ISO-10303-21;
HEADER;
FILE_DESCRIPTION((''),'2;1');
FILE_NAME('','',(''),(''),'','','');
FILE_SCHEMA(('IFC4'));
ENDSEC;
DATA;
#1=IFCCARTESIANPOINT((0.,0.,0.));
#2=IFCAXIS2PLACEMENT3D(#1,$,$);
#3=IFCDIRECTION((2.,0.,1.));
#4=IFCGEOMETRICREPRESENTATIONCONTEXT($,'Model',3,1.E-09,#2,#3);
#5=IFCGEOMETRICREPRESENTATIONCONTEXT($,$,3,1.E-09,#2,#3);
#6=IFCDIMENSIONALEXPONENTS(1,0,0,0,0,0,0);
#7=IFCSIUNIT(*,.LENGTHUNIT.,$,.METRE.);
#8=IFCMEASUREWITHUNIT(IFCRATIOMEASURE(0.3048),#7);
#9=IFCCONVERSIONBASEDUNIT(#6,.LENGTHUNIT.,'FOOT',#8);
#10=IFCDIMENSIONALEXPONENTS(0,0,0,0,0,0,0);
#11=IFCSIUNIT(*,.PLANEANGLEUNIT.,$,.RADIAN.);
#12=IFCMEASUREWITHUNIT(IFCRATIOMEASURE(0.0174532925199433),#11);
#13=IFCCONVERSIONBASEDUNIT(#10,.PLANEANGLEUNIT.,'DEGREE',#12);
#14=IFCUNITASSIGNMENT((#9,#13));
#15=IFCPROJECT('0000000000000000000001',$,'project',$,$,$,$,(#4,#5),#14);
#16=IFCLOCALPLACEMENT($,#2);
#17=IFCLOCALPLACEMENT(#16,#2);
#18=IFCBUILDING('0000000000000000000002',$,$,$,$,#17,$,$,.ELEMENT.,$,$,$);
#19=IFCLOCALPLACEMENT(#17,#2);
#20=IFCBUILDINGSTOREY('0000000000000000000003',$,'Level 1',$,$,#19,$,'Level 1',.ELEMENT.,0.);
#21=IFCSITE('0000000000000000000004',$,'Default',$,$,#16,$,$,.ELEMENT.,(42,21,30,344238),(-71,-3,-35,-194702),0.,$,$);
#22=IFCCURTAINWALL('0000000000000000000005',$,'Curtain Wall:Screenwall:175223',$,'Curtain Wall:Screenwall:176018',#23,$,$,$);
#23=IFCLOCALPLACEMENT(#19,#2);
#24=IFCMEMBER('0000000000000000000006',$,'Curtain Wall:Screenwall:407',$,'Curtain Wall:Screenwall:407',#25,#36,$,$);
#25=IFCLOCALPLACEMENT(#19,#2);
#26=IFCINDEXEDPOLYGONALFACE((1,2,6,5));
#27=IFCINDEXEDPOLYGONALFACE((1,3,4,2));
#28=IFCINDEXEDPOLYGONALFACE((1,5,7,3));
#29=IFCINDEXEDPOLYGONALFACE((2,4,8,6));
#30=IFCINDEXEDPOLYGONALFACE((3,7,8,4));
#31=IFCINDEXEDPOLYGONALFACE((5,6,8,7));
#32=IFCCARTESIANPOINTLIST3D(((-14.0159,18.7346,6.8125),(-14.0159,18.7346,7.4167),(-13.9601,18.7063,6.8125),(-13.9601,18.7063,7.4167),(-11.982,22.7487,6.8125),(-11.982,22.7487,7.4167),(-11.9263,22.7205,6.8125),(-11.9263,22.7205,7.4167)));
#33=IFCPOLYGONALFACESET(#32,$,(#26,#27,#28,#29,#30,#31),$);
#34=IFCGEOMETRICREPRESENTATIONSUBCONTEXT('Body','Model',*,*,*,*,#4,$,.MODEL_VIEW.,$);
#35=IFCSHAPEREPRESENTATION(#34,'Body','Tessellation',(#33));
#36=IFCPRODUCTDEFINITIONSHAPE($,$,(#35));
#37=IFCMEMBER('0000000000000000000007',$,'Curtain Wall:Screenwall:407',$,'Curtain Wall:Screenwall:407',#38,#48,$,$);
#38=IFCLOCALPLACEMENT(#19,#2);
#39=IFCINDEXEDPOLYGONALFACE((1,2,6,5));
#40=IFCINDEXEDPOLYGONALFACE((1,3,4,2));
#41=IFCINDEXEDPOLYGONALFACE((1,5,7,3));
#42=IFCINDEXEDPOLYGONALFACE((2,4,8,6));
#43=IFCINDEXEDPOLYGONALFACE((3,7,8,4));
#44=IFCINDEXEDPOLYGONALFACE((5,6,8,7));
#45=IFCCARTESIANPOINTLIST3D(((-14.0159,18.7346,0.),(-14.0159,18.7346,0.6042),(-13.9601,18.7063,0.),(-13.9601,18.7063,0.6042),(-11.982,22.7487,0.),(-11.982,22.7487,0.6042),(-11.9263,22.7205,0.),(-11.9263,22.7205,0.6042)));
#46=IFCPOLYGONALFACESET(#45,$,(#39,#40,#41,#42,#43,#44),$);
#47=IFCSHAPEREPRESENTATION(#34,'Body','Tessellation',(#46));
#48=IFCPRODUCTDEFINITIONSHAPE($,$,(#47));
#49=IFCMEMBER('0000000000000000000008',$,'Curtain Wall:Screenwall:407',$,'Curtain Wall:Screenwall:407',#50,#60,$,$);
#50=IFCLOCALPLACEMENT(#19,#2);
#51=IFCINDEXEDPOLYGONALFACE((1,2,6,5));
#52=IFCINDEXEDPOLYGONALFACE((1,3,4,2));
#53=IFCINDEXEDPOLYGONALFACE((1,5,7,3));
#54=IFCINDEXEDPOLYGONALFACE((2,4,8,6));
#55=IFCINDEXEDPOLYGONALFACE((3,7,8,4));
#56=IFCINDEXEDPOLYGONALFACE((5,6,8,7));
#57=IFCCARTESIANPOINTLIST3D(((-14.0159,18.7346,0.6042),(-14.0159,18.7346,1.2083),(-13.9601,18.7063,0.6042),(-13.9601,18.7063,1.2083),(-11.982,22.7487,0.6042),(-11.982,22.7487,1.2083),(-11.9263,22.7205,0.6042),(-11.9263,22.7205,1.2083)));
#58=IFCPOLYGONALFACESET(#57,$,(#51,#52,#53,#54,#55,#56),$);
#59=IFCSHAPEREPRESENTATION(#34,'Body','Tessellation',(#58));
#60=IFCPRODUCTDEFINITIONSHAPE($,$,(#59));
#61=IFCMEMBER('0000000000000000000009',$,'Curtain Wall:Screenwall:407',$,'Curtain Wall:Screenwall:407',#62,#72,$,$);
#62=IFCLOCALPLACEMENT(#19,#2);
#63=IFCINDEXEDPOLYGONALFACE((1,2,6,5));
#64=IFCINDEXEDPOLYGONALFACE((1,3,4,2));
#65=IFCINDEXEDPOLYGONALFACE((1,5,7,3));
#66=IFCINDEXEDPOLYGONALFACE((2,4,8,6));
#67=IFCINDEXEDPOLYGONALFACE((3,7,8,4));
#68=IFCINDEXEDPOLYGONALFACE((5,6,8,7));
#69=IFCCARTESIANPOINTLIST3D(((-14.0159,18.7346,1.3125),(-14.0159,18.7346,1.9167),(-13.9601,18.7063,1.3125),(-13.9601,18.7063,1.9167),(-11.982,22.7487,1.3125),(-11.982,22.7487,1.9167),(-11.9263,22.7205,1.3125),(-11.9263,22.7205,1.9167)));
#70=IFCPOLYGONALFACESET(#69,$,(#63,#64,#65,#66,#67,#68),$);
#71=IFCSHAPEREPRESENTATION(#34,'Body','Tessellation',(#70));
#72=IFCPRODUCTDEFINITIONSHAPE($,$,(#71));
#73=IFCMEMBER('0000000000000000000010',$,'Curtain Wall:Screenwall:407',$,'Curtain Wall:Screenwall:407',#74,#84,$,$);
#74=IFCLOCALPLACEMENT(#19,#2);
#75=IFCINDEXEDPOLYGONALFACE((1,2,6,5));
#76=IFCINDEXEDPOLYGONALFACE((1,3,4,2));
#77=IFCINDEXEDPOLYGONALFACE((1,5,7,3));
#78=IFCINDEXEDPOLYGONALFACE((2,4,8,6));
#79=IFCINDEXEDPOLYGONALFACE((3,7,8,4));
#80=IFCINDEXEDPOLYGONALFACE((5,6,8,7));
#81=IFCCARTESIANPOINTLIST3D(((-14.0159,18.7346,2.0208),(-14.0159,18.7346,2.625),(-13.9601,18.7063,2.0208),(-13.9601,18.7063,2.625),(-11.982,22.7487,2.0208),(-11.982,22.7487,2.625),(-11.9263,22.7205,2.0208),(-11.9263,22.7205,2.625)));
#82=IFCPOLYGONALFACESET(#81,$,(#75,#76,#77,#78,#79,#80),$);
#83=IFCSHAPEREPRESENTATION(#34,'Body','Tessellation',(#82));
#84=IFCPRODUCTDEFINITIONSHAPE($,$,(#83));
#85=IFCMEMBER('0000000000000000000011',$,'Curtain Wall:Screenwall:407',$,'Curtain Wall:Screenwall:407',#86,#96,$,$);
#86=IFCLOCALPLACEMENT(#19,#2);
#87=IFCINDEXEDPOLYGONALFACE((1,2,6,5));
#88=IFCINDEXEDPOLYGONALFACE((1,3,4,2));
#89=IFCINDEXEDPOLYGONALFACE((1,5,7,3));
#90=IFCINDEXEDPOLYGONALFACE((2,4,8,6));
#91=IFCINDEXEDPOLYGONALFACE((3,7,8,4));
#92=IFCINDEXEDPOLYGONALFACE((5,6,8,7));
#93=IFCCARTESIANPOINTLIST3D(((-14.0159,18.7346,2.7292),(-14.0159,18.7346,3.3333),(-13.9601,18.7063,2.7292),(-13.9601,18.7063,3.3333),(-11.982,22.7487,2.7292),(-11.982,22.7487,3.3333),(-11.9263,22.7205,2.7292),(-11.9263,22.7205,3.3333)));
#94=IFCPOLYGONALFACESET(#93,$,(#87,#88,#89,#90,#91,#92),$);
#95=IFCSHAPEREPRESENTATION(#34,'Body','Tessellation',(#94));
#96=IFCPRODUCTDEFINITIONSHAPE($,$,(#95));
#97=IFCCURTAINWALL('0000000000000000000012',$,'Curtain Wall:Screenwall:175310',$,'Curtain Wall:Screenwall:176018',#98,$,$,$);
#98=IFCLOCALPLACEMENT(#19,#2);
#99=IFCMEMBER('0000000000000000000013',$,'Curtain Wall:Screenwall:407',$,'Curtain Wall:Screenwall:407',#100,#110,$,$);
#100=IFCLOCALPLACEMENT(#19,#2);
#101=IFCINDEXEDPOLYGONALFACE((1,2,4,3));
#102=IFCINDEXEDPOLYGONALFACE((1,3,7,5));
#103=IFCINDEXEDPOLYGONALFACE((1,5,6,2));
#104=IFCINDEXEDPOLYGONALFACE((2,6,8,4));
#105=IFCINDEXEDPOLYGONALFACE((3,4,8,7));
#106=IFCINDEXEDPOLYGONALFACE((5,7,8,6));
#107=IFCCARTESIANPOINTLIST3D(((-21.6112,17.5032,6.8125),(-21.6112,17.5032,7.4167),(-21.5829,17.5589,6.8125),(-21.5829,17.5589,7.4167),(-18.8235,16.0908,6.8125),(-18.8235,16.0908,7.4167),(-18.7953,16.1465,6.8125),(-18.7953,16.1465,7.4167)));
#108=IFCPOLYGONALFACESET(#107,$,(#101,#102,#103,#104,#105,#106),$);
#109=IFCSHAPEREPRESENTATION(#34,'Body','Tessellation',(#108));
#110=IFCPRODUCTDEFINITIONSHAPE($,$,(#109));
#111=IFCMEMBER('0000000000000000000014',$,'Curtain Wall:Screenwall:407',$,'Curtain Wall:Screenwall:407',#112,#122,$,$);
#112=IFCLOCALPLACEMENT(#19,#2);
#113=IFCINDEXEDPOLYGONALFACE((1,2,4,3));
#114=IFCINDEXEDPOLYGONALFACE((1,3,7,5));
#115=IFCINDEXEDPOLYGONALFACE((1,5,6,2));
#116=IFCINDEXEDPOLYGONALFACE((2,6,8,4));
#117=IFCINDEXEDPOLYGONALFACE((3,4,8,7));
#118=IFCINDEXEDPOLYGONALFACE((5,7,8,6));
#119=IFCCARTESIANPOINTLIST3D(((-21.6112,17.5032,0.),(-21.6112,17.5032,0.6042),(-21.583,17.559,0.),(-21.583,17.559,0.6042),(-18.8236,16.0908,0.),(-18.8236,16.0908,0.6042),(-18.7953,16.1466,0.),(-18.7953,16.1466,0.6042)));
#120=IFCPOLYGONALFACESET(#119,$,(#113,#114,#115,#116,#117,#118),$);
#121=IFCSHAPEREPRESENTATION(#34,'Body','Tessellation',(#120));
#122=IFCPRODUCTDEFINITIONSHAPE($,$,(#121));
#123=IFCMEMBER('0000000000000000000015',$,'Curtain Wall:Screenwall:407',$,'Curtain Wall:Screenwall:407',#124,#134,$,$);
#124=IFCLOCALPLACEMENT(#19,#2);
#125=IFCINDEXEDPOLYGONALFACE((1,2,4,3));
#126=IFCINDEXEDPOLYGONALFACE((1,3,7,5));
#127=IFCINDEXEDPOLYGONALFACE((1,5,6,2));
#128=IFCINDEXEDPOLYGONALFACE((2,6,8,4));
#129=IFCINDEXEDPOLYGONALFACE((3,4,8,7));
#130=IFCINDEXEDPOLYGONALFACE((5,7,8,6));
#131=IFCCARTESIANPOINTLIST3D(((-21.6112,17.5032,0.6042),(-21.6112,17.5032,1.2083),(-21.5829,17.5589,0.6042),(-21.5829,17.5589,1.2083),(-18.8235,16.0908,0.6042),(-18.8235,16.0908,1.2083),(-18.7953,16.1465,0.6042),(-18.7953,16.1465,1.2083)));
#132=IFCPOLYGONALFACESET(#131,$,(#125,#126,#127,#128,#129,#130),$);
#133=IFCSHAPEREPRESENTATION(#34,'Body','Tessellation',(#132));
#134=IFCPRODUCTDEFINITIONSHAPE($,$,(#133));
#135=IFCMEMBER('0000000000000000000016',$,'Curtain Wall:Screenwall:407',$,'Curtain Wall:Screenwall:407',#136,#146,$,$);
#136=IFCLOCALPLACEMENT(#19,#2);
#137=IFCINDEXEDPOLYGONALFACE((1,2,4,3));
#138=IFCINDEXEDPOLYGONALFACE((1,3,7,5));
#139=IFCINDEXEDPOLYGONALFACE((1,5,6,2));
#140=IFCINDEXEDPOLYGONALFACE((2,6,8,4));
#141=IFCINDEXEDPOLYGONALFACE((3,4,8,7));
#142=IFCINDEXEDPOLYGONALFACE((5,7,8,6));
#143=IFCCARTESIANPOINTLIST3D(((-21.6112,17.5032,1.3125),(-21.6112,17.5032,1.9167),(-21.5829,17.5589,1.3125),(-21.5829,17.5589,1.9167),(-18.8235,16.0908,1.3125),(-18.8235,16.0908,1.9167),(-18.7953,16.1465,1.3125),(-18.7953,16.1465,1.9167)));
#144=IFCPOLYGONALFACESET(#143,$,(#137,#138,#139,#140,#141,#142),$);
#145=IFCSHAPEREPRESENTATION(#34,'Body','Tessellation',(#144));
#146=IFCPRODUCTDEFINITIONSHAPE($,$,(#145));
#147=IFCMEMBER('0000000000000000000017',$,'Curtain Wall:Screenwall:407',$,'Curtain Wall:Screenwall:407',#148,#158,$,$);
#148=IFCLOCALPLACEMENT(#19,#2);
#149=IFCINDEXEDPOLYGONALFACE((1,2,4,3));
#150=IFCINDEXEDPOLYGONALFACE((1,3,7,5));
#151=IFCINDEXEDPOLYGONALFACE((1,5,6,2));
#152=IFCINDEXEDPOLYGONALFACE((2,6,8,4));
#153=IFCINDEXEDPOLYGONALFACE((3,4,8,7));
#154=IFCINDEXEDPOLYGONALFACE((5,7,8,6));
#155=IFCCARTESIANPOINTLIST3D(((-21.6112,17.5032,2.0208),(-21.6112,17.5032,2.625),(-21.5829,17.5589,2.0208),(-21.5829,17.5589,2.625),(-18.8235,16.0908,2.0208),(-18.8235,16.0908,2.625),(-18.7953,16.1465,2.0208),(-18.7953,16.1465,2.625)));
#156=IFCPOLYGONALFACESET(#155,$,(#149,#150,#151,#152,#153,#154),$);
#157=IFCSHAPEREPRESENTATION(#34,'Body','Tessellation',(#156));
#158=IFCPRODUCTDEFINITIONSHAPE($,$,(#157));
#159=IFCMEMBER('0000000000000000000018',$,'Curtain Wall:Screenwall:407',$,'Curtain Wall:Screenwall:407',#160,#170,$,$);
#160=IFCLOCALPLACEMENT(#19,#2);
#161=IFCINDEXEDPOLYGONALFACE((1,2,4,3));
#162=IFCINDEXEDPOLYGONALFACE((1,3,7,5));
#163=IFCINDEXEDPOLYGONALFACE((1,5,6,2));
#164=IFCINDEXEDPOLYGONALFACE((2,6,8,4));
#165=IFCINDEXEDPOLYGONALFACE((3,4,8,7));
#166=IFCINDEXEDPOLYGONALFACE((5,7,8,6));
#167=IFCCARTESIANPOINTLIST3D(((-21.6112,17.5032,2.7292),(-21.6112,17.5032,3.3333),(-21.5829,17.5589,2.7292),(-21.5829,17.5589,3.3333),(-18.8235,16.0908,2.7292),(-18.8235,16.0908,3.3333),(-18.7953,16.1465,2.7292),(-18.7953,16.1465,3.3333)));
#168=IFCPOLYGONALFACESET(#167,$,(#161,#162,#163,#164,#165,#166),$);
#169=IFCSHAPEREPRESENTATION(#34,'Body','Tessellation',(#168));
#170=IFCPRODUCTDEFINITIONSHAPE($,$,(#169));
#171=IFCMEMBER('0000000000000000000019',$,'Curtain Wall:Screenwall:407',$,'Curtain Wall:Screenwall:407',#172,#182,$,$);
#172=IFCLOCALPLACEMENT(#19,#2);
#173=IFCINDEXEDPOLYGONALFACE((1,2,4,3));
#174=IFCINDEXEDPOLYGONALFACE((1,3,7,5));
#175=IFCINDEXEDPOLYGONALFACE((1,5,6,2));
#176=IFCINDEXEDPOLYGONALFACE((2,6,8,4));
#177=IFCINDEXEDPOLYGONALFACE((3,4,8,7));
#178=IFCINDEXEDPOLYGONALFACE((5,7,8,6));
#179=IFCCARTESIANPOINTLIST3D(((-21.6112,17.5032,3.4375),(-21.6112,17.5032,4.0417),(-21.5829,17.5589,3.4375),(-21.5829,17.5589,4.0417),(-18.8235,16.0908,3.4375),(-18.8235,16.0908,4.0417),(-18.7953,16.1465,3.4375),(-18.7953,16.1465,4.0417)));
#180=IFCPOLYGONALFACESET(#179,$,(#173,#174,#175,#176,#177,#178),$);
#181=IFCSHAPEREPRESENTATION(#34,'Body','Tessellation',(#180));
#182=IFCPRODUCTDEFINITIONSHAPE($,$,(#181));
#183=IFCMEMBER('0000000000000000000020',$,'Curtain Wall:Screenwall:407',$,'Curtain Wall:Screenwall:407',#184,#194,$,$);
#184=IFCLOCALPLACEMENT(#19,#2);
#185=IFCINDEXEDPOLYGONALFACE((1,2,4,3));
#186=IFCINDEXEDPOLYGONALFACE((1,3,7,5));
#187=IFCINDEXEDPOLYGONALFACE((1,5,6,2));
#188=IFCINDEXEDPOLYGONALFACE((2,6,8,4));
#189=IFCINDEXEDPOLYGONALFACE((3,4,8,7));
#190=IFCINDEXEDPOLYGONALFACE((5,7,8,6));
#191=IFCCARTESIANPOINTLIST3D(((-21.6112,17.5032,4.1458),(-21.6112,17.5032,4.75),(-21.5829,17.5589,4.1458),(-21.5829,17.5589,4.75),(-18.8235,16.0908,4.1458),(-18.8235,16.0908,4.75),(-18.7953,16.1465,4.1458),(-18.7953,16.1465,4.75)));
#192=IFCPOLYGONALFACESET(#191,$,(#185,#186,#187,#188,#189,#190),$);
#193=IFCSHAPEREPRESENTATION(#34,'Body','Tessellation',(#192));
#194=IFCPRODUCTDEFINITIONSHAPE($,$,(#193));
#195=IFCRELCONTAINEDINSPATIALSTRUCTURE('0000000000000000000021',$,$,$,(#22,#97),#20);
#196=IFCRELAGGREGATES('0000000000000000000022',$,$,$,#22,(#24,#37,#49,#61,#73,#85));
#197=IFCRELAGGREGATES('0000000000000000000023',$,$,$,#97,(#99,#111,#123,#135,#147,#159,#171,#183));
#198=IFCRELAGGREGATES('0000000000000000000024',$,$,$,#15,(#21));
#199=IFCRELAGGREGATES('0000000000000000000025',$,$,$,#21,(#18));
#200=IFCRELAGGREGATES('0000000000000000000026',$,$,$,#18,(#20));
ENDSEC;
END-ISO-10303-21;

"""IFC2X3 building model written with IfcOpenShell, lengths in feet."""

from ifc_helpers import new_model, entity, si_unit, converted_unit, direction, frame, frame_2d, origin, origin_2d_with_axis, place, context, subcontext, project, spatial, rectangle, extrude, element, aggregate, save


model = new_model("IFC2X3")

# Units and contexts
model_context = context("Model", 3, precision=1e-09, world=origin(), true_north=direction((2.0, 0.0, 1.0)))
context_of_model = context(None, 3, precision=1e-09, world=origin(), true_north=direction((2.0, 0.0, 1.0)))
body_context = subcontext(model_context, "Body", "Model", "MODEL_VIEW")
ifc_project = project(units=[converted_unit("LENGTHUNIT", "FOOT", entity("IfcRatioMeasure", 0.3048), si_unit("LENGTHUNIT", "METRE"), dimensions=[1, 0, 0, 0, 0, 0, 0]), converted_unit("PLANEANGLEUNIT", "DEGREE", entity("IfcRatioMeasure", 0.0174532925199433), si_unit("PLANEANGLEUNIT", "RADIAN"), dimensions=[0, 0, 0, 0, 0, 0, 0])], contexts=[model_context, context_of_model])

# Site, building, storey
site_placement = place(None, origin())
site = spatial("IfcSite", under=ifc_project, at=site_placement, Name="Default", CompositionType="ELEMENT", RefLatitude=(42, 21, 30, 344238), RefLongitude=(-71, -3, -35, -194702), RefElevation=0.0)
building_placement = place(site_placement, origin())
building = spatial("IfcBuilding", under=site, at=building_placement, CompositionType="ELEMENT")
storey_placement = place(building_placement, origin())
storey = spatial("IfcBuildingStorey", under=building, at=storey_placement, Name="Level 1", LongName="Level 1", CompositionType="ELEMENT", Elevation=0.0)

# Curtain walls, members
curtain_wall_1_placement = place(storey_placement, origin())
curtain_wall_1 = element("IfcCurtainWall", 1, at=curtain_wall_1_placement, inside=storey, Name="Curtain Wall:Screenwall:175223", ObjectType="Curtain Wall:Screenwall:176018")
member_1_placement = place(curtain_wall_1_placement, frame((-14.0159, 18.7063, 6.8125)))
member_1 = element("IfcMember", 2, at=member_1_placement, Name="Curtain Wall:Screenwall:407", ObjectType="Curtain Wall:Screenwall:407", context=body_context, shape_type="SweptSolid", body=[
    extrude(rectangle(XDim=4.5, YDim=0.0625, at=origin_2d_with_axis()), frame((1.0448, 2.0212, 0.0), z_axis=(0.0, 0.0, 1.0), x_axis=(-0.451968, -0.892034, 0.0)), (0.0, 0.0, 1.0), 0.6042),
])
member_2_placement = place(curtain_wall_1_placement, frame((-14.0159, 18.7063, 0.0)))
member_2 = element("IfcMember", 3, at=member_2_placement, Name="Curtain Wall:Screenwall:407", ObjectType="Curtain Wall:Screenwall:407", context=body_context, shape_type="SweptSolid", body=[
    extrude(rectangle(XDim=4.5, YDim=0.0625, at=frame_2d((0.0, 0.0), x_axis=(1.0, 0.0))), frame((1.0448, 2.0212, 0.0), z_axis=(0.0, 0.0, 1.0), x_axis=(0.451968, 0.892034, 0.0)), (0.0, 0.0, 1.0), 0.6042),
])
member_3_placement = place(curtain_wall_1_placement, frame((-14.0159, 18.7063, 0.6042)))
member_3 = element("IfcMember", 4, at=member_3_placement, Name="Curtain Wall:Screenwall:407", ObjectType="Curtain Wall:Screenwall:407", context=body_context, shape_type="SweptSolid", body=[
    extrude(rectangle(XDim=4.5, YDim=0.0625, at=frame_2d((0.0, 0.0), x_axis=(1.0, 0.0))), frame((1.0448, 2.0212, 0.0), z_axis=(0.0, 0.0, 1.0), x_axis=(-0.451968, -0.892034, 0.0)), (0.0, 0.0, 1.0), 0.6042),
])
member_4_placement = place(curtain_wall_1_placement, frame((-14.0159, 18.7063, 1.3125)))
member_4 = element("IfcMember", 5, at=member_4_placement, Name="Curtain Wall:Screenwall:407", ObjectType="Curtain Wall:Screenwall:407", context=body_context, shape_type="SweptSolid", body=[
    extrude(rectangle(XDim=4.5, YDim=0.0625, at=frame_2d((0.0, 0.0), x_axis=(1.0, 0.0))), frame((1.0448, 2.0212, 0.0), z_axis=(0.0, 0.0, 1.0), x_axis=(-0.451968, -0.892034, 0.0)), (0.0, 0.0, 1.0), 0.6042),
])
member_5_placement = place(curtain_wall_1_placement, frame((-14.0159, 18.7063, 2.0208)))
member_5 = element("IfcMember", 6, at=member_5_placement, Name="Curtain Wall:Screenwall:407", ObjectType="Curtain Wall:Screenwall:407", context=body_context, shape_type="SweptSolid", body=[
    extrude(rectangle(XDim=4.5, YDim=0.0625, at=frame_2d((0.0, 0.0), x_axis=(1.0, 0.0))), frame((1.0448, 2.0212, 0.0), z_axis=(0.0, 0.0, 1.0), x_axis=(-0.451968, -0.892034, 0.0)), (0.0, 0.0, 1.0), 0.6042),
])
member_6_placement = place(curtain_wall_1_placement, frame((-14.0159, 18.7063, 2.7292)))
member_6 = element("IfcMember", 7, at=member_6_placement, Name="Curtain Wall:Screenwall:407", ObjectType="Curtain Wall:Screenwall:407", context=body_context, shape_type="SweptSolid", body=[
    extrude(rectangle(XDim=4.5, YDim=0.0625, at=frame_2d((0.0, 0.0), x_axis=(1.0, 0.0))), frame((1.0448, 2.0212, 0.0), z_axis=(0.0, 0.0, 1.0), x_axis=(-0.451968, -0.892034, 0.0)), (0.0, 0.0, 1.0), 0.6042),
])
aggregate(curtain_wall_1, [member_1, member_2, member_3, member_4, member_5, member_6])
curtain_wall_2_placement = place(storey_placement, origin())
curtain_wall_2 = element("IfcCurtainWall", 8, at=curtain_wall_2_placement, inside=storey, Name="Curtain Wall:Screenwall:175310", ObjectType="Curtain Wall:Screenwall:176018")
member_7_placement = place(curtain_wall_2_placement, frame((-21.6112, 16.0908, 6.8125)))
member_7 = element("IfcMember", 9, at=member_7_placement, Name="Curtain Wall:Screenwall:407", ObjectType="Curtain Wall:Screenwall:407", context=body_context, shape_type="SweptSolid", body=[
    extrude(rectangle(XDim=3.1251, YDim=0.0625, at=origin_2d_with_axis()), frame((1.408, 0.7341, 0.0), z_axis=(0.0, 0.0, 1.0), x_axis=(0.892034, -0.451968, 0.0)), (0.0, 0.0, 1.0), 0.6042),
])
member_8_placement = place(curtain_wall_2_placement, frame((-21.6112, 16.0908, 0.0)))
member_8 = element("IfcMember", 10, at=member_8_placement, Name="Curtain Wall:Screenwall:407", ObjectType="Curtain Wall:Screenwall:407", context=body_context, shape_type="SweptSolid", body=[
    extrude(rectangle(XDim=3.1251, YDim=0.0625, at=frame_2d((0.0, 0.0), x_axis=(1.0, 0.0))), frame((1.408, 0.7341, 0.0), z_axis=(0.0, 0.0, 1.0), x_axis=(-0.892034, 0.451968, 0.0)), (0.0, 0.0, 1.0), 0.6042),
])
member_9_placement = place(curtain_wall_2_placement, frame((-21.6112, 16.0908, 0.6042)))
member_9 = element("IfcMember", 11, at=member_9_placement, Name="Curtain Wall:Screenwall:407", ObjectType="Curtain Wall:Screenwall:407", context=body_context, shape_type="SweptSolid", body=[
    extrude(rectangle(XDim=3.1251, YDim=0.0625, at=origin_2d_with_axis()), frame((1.408, 0.7341, 0.0), z_axis=(0.0, 0.0, 1.0), x_axis=(0.892034, -0.451968, 0.0)), (0.0, 0.0, 1.0), 0.6042),
])
member_10_placement = place(curtain_wall_2_placement, frame((-21.6112, 16.0908, 1.3125)))
member_10 = element("IfcMember", 12, at=member_10_placement, Name="Curtain Wall:Screenwall:407", ObjectType="Curtain Wall:Screenwall:407", context=body_context, shape_type="SweptSolid", body=[
    extrude(rectangle(XDim=3.1251, YDim=0.0625, at=origin_2d_with_axis()), frame((1.408, 0.7341, 0.0), z_axis=(0.0, 0.0, 1.0), x_axis=(0.892034, -0.451968, 0.0)), (0.0, 0.0, 1.0), 0.6042),
])
member_11_placement = place(curtain_wall_2_placement, frame((-21.6112, 16.0908, 2.0208)))
member_11 = element("IfcMember", 13, at=member_11_placement, Name="Curtain Wall:Screenwall:407", ObjectType="Curtain Wall:Screenwall:407", context=body_context, shape_type="SweptSolid", body=[
    extrude(rectangle(XDim=3.1251, YDim=0.0625, at=origin_2d_with_axis()), frame((1.408, 0.7341, 0.0), z_axis=(0.0, 0.0, 1.0), x_axis=(0.892034, -0.451968, 0.0)), (0.0, 0.0, 1.0), 0.6042),
])
member_12_placement = place(curtain_wall_2_placement, frame((-21.6112, 16.0908, 2.7292)))
member_12 = element("IfcMember", 14, at=member_12_placement, Name="Curtain Wall:Screenwall:407", ObjectType="Curtain Wall:Screenwall:407", context=body_context, shape_type="SweptSolid", body=[
    extrude(rectangle(XDim=3.1251, YDim=0.0625, at=origin_2d_with_axis()), frame((1.408, 0.7341, 0.0), z_axis=(0.0, 0.0, 1.0), x_axis=(0.892034, -0.451968, 0.0)), (0.0, 0.0, 1.0), 0.6042),
])
member_13_placement = place(curtain_wall_2_placement, frame((-21.6112, 16.0908, 3.4375)))
member_13 = element("IfcMember", 15, at=member_13_placement, Name="Curtain Wall:Screenwall:407", ObjectType="Curtain Wall:Screenwall:407", context=body_context, shape_type="SweptSolid", body=[
    extrude(rectangle(XDim=3.1251, YDim=0.0625, at=origin_2d_with_axis()), frame((1.408, 0.7341, 0.0), z_axis=(0.0, 0.0, 1.0), x_axis=(0.892034, -0.451968, 0.0)), (0.0, 0.0, 1.0), 0.6042),
])
member_14_placement = place(curtain_wall_2_placement, frame((-21.6112, 16.0908, 4.1458)))
member_14 = element("IfcMember", 16, at=member_14_placement, Name="Curtain Wall:Screenwall:407", ObjectType="Curtain Wall:Screenwall:407", context=body_context, shape_type="SweptSolid", body=[
    extrude(rectangle(XDim=3.1251, YDim=0.0625, at=origin_2d_with_axis()), frame((1.408, 0.7341, 0.0), z_axis=(0.0, 0.0, 1.0), x_axis=(0.892034, -0.451968, 0.0)), (0.0, 0.0, 1.0), 0.6042),
])
aggregate(curtain_wall_2, [member_7, member_8, member_9, member_10, member_11, member_12, member_13, member_14])

save(model, "model.ifc")
